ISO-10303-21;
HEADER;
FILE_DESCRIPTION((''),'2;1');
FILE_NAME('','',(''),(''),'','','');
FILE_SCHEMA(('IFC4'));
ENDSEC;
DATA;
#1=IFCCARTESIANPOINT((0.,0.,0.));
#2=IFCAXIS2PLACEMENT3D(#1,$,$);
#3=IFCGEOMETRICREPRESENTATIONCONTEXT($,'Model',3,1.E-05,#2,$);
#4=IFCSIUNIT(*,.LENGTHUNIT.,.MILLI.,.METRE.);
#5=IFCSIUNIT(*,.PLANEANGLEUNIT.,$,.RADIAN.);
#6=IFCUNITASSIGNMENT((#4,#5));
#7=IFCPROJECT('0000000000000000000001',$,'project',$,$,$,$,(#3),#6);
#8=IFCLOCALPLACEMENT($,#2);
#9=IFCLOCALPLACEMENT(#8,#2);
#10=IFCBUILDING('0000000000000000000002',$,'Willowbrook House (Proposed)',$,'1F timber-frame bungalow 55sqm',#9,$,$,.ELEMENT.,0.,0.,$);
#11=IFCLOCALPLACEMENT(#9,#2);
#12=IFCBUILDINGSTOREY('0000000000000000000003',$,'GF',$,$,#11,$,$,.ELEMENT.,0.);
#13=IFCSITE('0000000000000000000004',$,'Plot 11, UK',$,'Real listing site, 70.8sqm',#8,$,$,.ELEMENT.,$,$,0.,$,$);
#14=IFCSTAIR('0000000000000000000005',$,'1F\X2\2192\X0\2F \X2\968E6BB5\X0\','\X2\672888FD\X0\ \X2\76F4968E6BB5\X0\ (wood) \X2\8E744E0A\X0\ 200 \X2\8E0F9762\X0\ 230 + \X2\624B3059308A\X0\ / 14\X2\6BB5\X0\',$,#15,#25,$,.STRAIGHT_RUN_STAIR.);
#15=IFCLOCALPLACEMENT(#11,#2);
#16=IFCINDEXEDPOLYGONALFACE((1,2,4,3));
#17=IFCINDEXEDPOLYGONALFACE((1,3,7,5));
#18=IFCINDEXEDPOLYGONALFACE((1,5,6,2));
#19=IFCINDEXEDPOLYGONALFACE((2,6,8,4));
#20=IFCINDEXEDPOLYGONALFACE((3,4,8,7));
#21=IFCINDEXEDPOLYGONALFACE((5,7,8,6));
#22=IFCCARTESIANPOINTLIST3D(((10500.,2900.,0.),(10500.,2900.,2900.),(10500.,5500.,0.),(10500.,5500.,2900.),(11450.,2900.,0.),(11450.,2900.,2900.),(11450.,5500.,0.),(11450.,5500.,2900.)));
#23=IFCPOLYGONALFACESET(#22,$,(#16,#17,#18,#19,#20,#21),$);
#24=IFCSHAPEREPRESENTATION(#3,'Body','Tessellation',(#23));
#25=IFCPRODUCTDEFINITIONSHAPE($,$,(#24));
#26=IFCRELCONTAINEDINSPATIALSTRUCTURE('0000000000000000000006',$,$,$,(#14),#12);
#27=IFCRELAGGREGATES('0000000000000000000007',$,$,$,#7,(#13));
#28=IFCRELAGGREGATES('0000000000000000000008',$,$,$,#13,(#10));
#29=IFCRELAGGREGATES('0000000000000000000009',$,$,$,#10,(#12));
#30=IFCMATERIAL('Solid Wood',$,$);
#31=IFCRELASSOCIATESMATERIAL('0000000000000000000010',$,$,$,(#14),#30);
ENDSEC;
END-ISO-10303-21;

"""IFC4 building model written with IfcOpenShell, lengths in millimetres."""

from ifc_helpers import new_model, si_unit, frame, frame_2d, origin, place, context, project, spatial, rectangle, extrude, material, element, save


model = new_model("IFC4")

# Units and contexts
model_context = context("Model", 3, precision=1e-05, world=origin())
ifc_project = project(units=[si_unit("LENGTHUNIT", "METRE", prefix="MILLI"), si_unit("PLANEANGLEUNIT", "RADIAN")], contexts=[model_context])

# Site, building, storey
site_placement = place(None, origin())
site = spatial("IfcSite", under=ifc_project, at=site_placement, Name="Plot 11, UK", ObjectType="Real listing site, 70.8sqm", CompositionType="ELEMENT", RefElevation=0.0)
building_placement = place(site_placement, origin())
building = spatial("IfcBuilding", under=site, at=building_placement, Name="Willowbrook House (Proposed)", ObjectType="1F timber-frame bungalow 55sqm", CompositionType="ELEMENT", ElevationOfRefHeight=0.0, ElevationOfTerrain=0.0)
storey_placement = place(building_placement, origin())
storey = spatial("IfcBuildingStorey", under=building, at=storey_placement, Name="GF", CompositionType="ELEMENT", Elevation=0.0)

# Shared definitions
ifc_material_1 = material(Name="Solid Wood")

# Stair
stair_placement = place(storey_placement, frame((5250.0, 1450.0, 0.0)))
element("IfcStair", 1, at=stair_placement, inside=storey, material=ifc_material_1, Name="1F→2F 階段", Description="木製 直階段 (wood) 蹴上 200 踏面 230 + 手すり / 14段", PredefinedType="STRAIGHT_RUN_STAIR", context=model_context, shape_type="SweptSolid", body=[
    extrude(rectangle(XDim=950.0, YDim=2600.0, at=frame_2d((475.0, 1300.0))), frame((5250.0, 1450.0, 0.0)), (0.0, 0.0, 1.0), 2900.0),
])

save(model, "model.ifc")
